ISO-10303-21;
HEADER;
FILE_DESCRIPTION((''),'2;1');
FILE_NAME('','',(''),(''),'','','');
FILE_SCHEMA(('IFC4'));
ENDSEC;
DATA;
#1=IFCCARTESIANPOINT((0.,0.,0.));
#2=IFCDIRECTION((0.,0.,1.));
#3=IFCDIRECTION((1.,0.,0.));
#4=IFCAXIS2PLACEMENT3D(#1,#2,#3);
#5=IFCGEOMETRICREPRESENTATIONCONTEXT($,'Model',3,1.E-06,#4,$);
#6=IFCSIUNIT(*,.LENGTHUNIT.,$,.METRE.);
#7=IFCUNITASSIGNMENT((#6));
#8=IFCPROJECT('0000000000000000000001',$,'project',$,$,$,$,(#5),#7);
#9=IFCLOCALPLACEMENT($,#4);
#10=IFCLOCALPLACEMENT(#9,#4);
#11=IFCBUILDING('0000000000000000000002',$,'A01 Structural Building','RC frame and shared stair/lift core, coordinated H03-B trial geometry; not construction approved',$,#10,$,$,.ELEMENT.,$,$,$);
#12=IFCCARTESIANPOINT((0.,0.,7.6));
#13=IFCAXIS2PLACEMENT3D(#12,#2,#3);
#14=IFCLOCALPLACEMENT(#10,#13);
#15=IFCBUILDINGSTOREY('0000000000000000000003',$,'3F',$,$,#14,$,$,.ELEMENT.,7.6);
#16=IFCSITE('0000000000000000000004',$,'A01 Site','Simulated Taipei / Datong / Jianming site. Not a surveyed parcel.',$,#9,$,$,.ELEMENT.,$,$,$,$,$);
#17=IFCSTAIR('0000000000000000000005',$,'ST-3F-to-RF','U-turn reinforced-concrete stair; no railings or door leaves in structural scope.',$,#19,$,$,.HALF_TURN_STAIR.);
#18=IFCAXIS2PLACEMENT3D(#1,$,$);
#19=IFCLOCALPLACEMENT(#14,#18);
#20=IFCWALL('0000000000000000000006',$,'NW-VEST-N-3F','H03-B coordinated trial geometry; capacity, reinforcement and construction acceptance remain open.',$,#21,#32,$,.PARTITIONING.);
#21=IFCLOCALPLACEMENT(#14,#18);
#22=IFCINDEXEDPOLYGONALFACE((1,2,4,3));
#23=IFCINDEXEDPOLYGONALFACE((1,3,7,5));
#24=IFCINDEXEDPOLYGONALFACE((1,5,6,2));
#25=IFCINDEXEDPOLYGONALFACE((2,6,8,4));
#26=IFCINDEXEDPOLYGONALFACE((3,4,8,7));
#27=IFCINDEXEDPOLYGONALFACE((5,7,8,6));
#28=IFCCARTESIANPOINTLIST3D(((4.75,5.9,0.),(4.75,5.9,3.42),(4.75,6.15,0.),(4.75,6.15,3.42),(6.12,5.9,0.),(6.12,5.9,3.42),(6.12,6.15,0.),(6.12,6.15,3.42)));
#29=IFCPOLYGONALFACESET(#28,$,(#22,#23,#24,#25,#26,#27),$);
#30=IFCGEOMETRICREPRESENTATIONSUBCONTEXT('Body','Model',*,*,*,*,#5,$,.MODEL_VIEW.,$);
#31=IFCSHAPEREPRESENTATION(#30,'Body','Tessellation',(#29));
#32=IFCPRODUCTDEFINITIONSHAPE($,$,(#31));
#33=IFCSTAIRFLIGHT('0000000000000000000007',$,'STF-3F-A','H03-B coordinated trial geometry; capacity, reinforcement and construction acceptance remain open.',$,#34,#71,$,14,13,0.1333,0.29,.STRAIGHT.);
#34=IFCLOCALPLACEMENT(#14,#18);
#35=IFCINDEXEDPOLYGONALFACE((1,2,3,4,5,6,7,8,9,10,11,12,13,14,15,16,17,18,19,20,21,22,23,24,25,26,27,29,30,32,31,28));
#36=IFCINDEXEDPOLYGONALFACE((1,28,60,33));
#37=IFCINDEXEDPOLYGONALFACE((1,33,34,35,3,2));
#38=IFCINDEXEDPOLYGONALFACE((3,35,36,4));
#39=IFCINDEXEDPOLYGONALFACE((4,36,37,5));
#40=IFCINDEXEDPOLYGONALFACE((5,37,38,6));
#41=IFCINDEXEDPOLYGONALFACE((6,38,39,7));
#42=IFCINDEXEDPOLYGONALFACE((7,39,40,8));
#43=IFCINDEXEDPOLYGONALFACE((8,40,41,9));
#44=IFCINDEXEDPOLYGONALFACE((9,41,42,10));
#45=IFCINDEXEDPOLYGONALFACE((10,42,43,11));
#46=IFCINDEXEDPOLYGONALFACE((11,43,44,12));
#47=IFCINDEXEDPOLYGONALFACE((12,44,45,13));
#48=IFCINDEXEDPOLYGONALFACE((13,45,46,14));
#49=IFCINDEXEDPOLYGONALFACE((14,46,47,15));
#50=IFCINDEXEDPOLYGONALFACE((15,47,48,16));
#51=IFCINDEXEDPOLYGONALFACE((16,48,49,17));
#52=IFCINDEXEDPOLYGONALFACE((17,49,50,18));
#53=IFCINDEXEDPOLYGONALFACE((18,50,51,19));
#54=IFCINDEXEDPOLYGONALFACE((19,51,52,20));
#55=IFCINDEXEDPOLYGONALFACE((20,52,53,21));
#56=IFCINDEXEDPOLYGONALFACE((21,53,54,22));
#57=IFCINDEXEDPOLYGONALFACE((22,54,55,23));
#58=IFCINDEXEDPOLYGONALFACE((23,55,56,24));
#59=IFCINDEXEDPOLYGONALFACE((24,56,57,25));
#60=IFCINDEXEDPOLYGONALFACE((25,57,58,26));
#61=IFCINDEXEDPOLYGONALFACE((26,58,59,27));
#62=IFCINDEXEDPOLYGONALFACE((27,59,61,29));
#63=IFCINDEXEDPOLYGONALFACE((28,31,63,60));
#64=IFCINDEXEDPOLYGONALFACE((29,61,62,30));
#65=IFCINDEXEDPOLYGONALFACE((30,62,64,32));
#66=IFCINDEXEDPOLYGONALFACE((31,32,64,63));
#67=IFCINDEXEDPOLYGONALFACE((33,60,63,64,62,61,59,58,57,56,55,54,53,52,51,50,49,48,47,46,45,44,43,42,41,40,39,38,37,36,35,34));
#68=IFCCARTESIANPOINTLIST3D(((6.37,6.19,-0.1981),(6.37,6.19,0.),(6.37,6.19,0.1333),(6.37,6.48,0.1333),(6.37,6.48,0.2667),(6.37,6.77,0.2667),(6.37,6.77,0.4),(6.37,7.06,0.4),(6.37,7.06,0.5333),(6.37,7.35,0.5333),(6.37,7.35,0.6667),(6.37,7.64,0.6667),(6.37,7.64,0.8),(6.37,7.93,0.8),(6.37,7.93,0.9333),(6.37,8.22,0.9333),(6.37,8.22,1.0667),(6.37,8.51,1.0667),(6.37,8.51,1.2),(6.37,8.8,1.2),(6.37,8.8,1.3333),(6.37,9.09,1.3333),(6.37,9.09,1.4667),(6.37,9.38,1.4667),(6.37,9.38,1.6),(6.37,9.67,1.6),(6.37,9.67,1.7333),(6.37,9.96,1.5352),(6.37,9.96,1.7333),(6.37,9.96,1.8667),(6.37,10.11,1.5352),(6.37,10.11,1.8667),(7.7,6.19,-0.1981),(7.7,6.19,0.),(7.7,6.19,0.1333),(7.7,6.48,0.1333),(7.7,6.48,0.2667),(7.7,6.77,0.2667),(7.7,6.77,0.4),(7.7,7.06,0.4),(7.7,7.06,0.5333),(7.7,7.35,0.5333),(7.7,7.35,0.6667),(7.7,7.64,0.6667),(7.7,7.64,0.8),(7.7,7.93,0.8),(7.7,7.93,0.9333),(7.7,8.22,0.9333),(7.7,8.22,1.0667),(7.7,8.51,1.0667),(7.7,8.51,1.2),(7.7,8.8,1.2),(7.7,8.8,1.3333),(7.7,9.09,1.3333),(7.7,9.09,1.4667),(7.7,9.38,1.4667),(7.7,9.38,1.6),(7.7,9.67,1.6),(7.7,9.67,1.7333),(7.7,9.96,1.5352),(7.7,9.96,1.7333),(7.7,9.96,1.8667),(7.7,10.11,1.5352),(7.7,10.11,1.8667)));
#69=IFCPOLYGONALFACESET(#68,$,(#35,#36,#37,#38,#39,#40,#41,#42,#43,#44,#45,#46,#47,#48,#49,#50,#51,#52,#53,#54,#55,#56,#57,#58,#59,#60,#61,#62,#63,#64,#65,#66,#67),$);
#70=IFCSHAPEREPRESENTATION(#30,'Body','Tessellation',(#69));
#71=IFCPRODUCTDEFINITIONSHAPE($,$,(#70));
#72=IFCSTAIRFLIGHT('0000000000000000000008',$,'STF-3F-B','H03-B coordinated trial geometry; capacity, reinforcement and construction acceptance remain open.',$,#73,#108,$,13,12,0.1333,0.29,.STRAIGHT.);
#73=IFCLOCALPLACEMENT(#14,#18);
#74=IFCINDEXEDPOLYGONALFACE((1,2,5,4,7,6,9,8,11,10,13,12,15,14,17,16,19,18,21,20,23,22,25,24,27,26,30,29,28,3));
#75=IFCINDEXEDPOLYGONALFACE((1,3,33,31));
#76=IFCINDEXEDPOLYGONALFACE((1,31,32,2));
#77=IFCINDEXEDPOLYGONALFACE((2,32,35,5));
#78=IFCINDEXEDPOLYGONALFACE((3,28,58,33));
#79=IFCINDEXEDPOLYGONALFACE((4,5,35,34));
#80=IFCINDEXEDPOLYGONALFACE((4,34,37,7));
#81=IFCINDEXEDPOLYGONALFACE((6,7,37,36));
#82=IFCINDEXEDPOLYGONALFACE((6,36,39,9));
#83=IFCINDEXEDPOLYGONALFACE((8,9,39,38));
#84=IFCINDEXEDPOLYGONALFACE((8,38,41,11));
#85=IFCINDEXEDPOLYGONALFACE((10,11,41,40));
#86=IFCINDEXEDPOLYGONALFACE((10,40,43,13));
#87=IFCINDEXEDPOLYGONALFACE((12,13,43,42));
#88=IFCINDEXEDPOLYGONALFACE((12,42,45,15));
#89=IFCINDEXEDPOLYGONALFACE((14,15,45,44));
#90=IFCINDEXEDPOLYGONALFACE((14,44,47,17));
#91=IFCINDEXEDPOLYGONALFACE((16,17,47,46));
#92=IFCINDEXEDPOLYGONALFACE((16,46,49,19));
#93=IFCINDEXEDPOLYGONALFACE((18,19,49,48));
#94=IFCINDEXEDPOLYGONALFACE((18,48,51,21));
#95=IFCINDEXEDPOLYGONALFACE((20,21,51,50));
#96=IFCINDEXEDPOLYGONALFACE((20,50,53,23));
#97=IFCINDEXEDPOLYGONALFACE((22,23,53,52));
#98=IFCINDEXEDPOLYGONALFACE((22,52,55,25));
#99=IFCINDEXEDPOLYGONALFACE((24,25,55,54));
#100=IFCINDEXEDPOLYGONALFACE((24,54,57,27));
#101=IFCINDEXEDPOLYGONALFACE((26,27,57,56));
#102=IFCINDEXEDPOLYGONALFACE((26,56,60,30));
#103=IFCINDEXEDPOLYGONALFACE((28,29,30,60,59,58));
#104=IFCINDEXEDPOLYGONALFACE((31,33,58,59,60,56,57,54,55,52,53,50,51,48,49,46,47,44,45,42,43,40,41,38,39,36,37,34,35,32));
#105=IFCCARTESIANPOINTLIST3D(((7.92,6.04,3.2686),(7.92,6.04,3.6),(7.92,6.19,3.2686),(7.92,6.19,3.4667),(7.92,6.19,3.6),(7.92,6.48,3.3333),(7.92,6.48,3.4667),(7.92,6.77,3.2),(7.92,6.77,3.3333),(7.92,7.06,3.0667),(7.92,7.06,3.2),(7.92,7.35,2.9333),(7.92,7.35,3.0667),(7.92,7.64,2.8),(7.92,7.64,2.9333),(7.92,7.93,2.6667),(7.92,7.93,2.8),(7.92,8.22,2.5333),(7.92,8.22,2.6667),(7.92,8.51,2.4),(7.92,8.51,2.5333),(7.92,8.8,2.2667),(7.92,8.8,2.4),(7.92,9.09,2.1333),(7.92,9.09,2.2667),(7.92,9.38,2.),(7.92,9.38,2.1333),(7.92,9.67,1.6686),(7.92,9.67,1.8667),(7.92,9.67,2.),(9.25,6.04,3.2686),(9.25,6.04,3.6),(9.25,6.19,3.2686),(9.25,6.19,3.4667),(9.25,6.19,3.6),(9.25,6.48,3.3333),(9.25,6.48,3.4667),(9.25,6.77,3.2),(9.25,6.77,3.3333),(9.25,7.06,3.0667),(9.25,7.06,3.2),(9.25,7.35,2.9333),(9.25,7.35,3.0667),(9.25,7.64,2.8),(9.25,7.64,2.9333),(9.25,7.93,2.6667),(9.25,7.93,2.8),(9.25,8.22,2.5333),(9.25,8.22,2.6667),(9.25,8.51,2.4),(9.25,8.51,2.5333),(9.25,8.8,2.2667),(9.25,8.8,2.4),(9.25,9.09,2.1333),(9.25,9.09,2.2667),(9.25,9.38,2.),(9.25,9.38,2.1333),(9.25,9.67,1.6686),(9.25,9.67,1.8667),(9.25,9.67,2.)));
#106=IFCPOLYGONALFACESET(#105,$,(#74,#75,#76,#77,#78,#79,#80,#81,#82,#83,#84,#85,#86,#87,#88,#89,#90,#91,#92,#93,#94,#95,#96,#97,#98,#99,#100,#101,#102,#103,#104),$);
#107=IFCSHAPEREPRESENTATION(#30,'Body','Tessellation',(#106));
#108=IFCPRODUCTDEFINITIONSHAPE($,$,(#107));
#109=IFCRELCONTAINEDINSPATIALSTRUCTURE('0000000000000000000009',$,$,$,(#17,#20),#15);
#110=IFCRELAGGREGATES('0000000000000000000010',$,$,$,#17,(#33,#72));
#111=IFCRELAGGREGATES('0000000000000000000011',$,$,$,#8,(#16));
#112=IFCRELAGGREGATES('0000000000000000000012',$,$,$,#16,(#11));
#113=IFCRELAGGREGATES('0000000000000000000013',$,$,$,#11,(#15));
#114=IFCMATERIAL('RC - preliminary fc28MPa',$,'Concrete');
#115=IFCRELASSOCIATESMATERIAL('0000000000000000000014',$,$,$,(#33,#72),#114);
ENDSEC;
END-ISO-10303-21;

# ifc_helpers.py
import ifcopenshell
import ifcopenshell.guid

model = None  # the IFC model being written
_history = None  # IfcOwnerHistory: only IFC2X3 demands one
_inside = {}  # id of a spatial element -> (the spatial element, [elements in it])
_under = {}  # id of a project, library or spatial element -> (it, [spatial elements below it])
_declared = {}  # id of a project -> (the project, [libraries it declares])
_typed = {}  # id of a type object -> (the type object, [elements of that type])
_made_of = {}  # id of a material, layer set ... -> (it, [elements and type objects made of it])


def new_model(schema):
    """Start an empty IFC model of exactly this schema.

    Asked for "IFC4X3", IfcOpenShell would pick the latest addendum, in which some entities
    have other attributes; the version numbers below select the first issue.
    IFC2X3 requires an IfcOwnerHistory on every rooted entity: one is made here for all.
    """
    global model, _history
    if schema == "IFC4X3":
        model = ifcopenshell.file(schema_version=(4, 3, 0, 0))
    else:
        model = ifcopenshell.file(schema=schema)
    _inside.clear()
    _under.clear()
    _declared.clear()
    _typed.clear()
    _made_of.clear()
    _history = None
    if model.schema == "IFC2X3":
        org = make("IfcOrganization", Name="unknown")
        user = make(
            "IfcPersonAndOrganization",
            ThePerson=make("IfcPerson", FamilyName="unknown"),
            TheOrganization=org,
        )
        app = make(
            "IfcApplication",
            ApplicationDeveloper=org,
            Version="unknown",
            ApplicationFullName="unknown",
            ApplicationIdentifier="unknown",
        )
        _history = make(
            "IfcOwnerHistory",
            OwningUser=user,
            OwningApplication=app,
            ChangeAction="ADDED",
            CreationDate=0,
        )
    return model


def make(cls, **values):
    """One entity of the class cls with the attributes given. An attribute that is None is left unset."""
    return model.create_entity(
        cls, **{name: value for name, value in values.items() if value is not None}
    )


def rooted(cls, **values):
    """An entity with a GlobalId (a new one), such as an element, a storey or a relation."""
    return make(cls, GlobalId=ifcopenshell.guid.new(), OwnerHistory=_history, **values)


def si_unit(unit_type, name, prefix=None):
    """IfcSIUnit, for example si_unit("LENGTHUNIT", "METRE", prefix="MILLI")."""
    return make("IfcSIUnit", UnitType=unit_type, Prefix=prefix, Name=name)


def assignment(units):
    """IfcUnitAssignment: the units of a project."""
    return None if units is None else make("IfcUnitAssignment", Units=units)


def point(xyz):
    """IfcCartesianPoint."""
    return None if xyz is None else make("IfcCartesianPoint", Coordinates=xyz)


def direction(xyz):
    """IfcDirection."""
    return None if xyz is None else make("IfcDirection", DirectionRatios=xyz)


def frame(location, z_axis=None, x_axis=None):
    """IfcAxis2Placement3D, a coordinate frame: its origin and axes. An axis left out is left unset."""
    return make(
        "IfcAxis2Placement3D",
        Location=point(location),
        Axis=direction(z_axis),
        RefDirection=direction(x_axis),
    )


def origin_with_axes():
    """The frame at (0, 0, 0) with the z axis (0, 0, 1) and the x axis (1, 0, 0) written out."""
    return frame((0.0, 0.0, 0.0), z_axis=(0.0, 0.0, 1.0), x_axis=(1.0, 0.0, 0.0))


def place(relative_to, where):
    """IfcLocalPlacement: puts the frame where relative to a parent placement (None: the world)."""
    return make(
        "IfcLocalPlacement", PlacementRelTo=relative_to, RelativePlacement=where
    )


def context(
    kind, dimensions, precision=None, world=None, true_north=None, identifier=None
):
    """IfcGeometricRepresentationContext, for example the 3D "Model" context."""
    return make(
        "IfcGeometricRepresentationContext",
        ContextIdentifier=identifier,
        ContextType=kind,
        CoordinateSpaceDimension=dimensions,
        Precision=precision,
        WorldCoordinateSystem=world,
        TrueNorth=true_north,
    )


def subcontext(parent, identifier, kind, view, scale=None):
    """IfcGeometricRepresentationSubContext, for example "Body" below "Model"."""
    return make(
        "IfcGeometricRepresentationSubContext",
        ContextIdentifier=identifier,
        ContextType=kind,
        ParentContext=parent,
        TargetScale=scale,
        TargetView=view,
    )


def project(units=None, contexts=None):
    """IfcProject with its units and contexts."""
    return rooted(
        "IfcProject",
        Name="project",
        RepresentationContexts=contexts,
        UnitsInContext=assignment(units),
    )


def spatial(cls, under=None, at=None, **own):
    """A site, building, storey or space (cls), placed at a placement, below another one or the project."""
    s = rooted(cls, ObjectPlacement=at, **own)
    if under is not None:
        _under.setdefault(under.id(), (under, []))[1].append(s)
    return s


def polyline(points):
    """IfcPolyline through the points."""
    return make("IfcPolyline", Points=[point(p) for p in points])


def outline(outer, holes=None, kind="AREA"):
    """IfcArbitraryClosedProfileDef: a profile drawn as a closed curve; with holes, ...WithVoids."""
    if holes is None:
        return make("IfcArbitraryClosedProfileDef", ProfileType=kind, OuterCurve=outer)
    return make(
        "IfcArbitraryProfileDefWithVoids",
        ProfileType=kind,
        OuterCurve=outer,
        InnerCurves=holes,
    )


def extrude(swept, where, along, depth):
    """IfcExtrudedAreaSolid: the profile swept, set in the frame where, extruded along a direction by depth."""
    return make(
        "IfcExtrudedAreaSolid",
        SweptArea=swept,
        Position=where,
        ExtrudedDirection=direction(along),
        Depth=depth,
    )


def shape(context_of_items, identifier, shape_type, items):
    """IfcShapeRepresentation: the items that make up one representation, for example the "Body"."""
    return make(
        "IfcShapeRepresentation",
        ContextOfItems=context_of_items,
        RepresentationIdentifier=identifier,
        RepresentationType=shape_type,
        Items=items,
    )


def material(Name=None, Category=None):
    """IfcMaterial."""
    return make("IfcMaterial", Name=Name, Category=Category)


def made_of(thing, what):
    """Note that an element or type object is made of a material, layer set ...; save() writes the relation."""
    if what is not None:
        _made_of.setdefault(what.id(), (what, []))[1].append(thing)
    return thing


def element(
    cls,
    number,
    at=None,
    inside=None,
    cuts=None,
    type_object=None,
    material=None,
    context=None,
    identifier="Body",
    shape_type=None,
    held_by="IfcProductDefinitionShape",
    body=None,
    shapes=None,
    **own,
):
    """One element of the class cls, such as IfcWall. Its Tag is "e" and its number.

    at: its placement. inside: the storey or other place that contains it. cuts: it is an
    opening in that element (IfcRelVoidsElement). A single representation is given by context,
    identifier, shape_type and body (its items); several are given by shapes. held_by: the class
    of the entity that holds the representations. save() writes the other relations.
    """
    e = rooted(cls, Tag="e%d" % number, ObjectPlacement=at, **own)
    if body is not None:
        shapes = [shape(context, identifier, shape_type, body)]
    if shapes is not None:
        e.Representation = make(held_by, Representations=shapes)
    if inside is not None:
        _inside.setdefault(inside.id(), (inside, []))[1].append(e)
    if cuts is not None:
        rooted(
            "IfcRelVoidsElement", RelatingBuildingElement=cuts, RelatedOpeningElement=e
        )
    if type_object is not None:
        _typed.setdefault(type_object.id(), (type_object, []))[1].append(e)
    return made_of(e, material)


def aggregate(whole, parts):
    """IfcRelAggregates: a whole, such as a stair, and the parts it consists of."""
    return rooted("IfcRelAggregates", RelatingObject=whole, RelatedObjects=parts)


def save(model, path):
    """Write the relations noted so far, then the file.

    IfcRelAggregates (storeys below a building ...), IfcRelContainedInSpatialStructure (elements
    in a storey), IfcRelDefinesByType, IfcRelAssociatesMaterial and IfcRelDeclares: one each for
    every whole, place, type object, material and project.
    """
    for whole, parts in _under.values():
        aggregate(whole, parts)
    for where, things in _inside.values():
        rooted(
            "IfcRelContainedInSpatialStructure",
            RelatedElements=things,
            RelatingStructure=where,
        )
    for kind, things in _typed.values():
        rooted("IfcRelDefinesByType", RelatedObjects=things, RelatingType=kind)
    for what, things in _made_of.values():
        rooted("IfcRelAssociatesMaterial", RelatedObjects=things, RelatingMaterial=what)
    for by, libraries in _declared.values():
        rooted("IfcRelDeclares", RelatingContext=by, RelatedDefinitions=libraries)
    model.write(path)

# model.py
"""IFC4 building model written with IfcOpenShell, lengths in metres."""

from ifc_helpers import new_model, si_unit, frame, origin_with_axes, place, context, subcontext, project, spatial, polyline, outline, extrude, material, element, aggregate, save


model = new_model("IFC4")

# Units and contexts
model_context = context("Model", 3, precision=1e-06, world=origin_with_axes())
body_context = subcontext(model_context, "Body", "Model", "MODEL_VIEW")
ifc_project = project(units=[si_unit("LENGTHUNIT", "METRE")], contexts=[model_context])

# Site, building, storey
site_placement = place(None, origin_with_axes())
site = spatial("IfcSite", under=ifc_project, at=site_placement, Name="A01 Site", Description="Simulated Taipei / Datong / Jianming site. Not a surveyed parcel.", CompositionType="ELEMENT")
building_placement = place(site_placement, origin_with_axes())
building = spatial("IfcBuilding", under=site, at=building_placement, Name="A01 Structural Building", Description="RC frame and shared stair/lift core, coordinated H03-B trial geometry; not construction approved", CompositionType="ELEMENT")
storey_placement = place(building_placement, frame((0.0, 0.0, 7.6), z_axis=(0.0, 0.0, 1.0), x_axis=(1.0, 0.0, 0.0)))
storey = spatial("IfcBuildingStorey", under=building, at=storey_placement, Name="3F", CompositionType="ELEMENT", Elevation=7.6)

# Shared definitions
ifc_material = material(Name="RC - preliminary fc28MPa", Category="Concrete")

# Stair
stair_placement = place(storey_placement, origin_with_axes())
stair = element("IfcStair", 1, at=stair_placement, inside=storey, Name="ST-3F-to-RF", Description="U-turn reinforced-concrete stair; no railings or door leaves in structural scope.", PredefinedType="HALF_TURN_STAIR")
placement = place(None, origin_with_axes())

# Wall
element("IfcWall", 2, at=placement, inside=storey, Name="NW-VEST-N-3F", Description="H03-B coordinated trial geometry; capacity, reinforcement and construction acceptance remain open.", PredefinedType="PARTITIONING", context=body_context, shape_type="SweptSolid", body=[
    extrude(outline(polyline([(6.12, 5.9), (6.12, 6.15), (4.75, 6.15), (4.75, 5.9), (6.12, 5.9)])), frame((0.0, 0.0, 7.6), z_axis=(0.0, 0.0, 1.0), x_axis=(1.0, 0.0, 0.0)), (0.0, 0.0, 1.0), 3.42),
])

# Stair flights
stair_flight_1 = element("IfcStairFlight", 3, at=placement, material=ifc_material, Name="STF-3F-A", Description="H03-B coordinated trial geometry; capacity, reinforcement and construction acceptance remain open.", NumberOfRisers=14, NumberOfTreads=13, PredefinedType="STRAIGHT", RiserHeight=0.1333, TreadLength=0.29, context=body_context, shape_type="SweptSolid", body=[
    extrude(outline(polyline([(0.0, 0.0), (0.0, 0.1333), (0.29, 0.1333), (0.29, 0.2667), (0.58, 0.2667), (0.58, 0.4), (0.87, 0.4), (0.87, 0.5333), (1.16, 0.5333), (1.16, 0.6667), (1.45, 0.6667), (1.45, 0.8), (1.74, 0.8), (1.74, 0.9333), (2.03, 0.9333), (2.03, 1.0667), (2.32, 1.0667), (2.32, 1.2), (2.61, 1.2), (2.61, 1.3333), (2.9, 1.3333), (2.9, 1.4667), (3.19, 1.4667), (3.19, 1.6), (3.48, 1.6), (3.48, 1.7333), (3.77, 1.7333), (3.77, 1.8667), (3.92, 1.8667), (3.92, 1.5352), (3.77, 1.5352), (0.0, -0.1981), (0.0, 0.0)])), frame((6.37, 6.19, 7.6), z_axis=(1.0, 0.0, 0.0), x_axis=(0.0, 1.0, 0.0)), (0.0, 0.0, 1.0), 1.33),
])
stair_flight_2 = element("IfcStairFlight", 4, at=placement, material=ifc_material, Name="STF-3F-B", Description="H03-B coordinated trial geometry; capacity, reinforcement and construction acceptance remain open.", NumberOfRisers=13, NumberOfTreads=12, PredefinedType="STRAIGHT", RiserHeight=0.1333, TreadLength=0.29, context=body_context, shape_type="SweptSolid", body=[
    extrude(outline(polyline([(0.0, 0.0), (0.0, 0.1333), (0.29, 0.1333), (0.29, 0.2667), (0.58, 0.2667), (0.58, 0.4), (0.87, 0.4), (0.87, 0.5333), (1.16, 0.5333), (1.16, 0.6667), (1.45, 0.6667), (1.45, 0.8), (1.74, 0.8), (1.74, 0.9333), (2.03, 0.9333), (2.03, 1.0667), (2.32, 1.0667), (2.32, 1.2), (2.61, 1.2), (2.61, 1.3333), (2.9, 1.3333), (2.9, 1.4667), (3.19, 1.4667), (3.19, 1.6), (3.48, 1.6), (3.48, 1.7333), (3.63, 1.7333), (3.63, 1.4019), (3.48, 1.4019), (0.0, -0.1981), (0.0, 0.0)])), frame((9.25, 9.67, 9.4667), z_axis=(-1.0, 0.0, 0.0), x_axis=(0.0, -1.0, 0.0)), (0.0, 0.0, 1.0), 1.33),
])
aggregate(stair, [stair_flight_1, stair_flight_2])

save(model, "model.ifc")
